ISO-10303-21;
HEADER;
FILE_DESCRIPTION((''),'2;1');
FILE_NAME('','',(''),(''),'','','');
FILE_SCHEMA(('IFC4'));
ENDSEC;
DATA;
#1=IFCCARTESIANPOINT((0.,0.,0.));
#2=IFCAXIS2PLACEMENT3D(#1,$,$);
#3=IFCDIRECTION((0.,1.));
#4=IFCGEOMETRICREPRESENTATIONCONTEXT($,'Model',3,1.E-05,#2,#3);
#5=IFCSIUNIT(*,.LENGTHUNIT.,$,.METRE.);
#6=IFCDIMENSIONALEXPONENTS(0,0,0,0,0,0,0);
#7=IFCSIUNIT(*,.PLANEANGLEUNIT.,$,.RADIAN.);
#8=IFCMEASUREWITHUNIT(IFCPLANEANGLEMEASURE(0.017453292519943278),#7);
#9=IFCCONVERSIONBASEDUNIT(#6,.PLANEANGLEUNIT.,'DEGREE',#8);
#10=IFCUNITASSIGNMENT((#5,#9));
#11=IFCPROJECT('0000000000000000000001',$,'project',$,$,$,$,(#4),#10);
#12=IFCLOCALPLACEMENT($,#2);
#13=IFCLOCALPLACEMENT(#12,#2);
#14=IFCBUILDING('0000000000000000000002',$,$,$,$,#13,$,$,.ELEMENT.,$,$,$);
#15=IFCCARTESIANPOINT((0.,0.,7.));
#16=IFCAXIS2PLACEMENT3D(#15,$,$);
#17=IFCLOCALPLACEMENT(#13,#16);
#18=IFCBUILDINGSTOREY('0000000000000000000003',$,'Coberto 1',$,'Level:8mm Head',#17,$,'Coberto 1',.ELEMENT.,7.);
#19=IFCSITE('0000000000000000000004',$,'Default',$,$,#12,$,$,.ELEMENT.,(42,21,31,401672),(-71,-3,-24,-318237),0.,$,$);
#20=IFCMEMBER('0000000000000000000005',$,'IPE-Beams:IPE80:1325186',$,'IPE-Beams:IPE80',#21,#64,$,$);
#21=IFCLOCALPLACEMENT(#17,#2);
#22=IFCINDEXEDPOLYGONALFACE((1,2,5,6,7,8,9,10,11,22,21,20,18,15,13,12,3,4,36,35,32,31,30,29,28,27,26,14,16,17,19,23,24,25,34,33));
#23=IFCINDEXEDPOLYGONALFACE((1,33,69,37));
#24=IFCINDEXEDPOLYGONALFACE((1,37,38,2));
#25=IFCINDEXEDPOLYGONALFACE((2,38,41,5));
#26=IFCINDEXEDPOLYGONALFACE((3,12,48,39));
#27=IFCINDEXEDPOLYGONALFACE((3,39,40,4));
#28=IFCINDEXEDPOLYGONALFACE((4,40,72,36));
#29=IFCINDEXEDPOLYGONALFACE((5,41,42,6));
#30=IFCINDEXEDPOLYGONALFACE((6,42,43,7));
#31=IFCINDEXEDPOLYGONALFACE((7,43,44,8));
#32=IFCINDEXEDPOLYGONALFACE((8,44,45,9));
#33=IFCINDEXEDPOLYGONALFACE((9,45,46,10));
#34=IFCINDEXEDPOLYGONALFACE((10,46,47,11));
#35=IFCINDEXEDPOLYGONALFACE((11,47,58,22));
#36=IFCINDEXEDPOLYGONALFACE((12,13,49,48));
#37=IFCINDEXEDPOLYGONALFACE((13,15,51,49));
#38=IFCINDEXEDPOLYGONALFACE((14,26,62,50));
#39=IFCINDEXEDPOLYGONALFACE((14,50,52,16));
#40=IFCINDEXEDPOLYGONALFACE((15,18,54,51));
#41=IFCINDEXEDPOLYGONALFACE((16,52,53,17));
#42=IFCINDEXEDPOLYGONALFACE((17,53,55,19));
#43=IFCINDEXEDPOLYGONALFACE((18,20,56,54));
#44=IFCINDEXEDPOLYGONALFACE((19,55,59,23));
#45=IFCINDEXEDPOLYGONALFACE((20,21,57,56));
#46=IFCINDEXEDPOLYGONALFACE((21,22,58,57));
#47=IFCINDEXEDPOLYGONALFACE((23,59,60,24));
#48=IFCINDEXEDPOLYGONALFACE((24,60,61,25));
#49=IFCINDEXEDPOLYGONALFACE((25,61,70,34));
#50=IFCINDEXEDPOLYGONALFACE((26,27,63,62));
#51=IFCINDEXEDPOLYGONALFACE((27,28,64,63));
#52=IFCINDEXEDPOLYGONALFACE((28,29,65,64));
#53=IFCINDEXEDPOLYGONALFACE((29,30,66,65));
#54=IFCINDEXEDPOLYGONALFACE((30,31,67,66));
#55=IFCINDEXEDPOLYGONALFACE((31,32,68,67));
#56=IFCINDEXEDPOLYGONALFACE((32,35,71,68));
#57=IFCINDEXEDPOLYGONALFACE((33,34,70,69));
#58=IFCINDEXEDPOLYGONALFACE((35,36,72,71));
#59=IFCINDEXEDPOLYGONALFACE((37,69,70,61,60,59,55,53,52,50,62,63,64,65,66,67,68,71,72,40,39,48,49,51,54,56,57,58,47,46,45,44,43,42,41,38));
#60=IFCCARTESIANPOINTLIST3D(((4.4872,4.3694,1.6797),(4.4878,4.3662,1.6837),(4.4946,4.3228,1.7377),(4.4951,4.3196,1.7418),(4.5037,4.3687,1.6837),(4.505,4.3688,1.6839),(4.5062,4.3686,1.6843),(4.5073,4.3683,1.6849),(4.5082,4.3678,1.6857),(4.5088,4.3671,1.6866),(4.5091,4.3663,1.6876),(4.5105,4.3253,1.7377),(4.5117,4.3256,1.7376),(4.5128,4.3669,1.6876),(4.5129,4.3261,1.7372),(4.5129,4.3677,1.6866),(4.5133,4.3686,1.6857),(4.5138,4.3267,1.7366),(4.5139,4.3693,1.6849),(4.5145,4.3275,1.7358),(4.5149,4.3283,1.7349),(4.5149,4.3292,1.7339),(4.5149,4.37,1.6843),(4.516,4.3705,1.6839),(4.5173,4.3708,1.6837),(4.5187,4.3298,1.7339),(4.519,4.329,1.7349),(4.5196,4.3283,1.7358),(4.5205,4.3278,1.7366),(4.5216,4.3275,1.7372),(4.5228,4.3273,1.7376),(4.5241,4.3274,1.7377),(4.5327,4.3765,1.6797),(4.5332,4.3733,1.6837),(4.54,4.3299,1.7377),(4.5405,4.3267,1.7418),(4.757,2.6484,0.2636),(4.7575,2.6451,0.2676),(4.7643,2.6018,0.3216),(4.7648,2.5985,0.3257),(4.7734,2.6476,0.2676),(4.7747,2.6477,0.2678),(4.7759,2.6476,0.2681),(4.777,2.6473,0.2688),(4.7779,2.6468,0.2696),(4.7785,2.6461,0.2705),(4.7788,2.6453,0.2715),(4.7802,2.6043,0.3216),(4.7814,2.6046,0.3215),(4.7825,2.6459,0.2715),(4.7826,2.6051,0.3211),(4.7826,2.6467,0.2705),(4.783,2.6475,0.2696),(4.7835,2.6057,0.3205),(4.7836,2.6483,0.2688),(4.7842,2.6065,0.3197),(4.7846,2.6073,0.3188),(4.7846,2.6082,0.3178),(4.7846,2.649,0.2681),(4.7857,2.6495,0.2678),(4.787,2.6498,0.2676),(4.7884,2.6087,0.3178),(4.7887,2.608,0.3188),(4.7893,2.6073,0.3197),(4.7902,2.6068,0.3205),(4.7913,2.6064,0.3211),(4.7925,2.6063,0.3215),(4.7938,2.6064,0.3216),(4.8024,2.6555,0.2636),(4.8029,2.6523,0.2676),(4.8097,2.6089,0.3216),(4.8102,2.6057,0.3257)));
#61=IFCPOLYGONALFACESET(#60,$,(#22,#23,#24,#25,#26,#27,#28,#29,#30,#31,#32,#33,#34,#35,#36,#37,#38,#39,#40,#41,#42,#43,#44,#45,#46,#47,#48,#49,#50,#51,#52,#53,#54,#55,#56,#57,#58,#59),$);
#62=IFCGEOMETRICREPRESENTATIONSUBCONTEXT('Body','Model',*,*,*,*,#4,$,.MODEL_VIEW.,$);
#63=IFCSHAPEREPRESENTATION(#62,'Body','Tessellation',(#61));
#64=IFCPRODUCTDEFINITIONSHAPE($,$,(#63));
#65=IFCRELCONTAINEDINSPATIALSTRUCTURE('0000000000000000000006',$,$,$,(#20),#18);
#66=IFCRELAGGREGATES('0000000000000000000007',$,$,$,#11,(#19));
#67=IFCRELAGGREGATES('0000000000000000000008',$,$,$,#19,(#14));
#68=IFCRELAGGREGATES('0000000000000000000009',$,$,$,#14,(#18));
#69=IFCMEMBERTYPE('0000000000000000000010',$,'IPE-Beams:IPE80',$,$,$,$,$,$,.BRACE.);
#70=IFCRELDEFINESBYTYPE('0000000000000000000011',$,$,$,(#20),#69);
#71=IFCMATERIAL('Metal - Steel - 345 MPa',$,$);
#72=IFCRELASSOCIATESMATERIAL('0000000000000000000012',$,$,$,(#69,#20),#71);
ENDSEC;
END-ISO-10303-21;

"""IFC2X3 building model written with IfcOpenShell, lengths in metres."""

from ifc_helpers import new_model, entity, si_unit, converted_unit, direction, frame, frame_2d, origin, place, context, subcontext, project, spatial, polyline, circle_curve, parameter, trimmed, segment, composite_curve, outline, extrude, source, transform, mapped, material, type_object, type_shapes, element, save


model = new_model("IFC2X3")

# Units and contexts
model_context = context("Model", 3, precision=1e-05, world=origin(), true_north=direction((0.0, 1.0)))
body_context = subcontext(model_context, "Body", "Model", "MODEL_VIEW")
ifc_project = project(units=[si_unit("LENGTHUNIT", "METRE"), converted_unit("PLANEANGLEUNIT", "DEGREE", entity("IfcPlaneAngleMeasure", 0.017453292519943278), si_unit("PLANEANGLEUNIT", "RADIAN"), dimensions=[0, 0, 0, 0, 0, 0, 0])], contexts=[model_context])

# Site, building, storey
site_placement = place(None, origin())
site = spatial("IfcSite", under=ifc_project, at=site_placement, Name="Default", CompositionType="ELEMENT", RefLatitude=(42, 21, 31, 401672), RefLongitude=(-71, -3, -24, -318237), RefElevation=0.0)
building_placement = place(site_placement, origin())
building = spatial("IfcBuilding", under=site, at=building_placement, CompositionType="ELEMENT")
storey_placement = place(building_placement, frame((0.0, 0.0, 7.0)))
storey = spatial("IfcBuildingStorey", under=building, at=storey_placement, Name="Coberto 1", ObjectType="Level:8mm Head", LongName="Coberto 1", CompositionType="ELEMENT", Elevation=7.0)

# Shared definitions
ifc_material_1 = material(Name="Metal - Steel - 345 MPa")

# Member
member_type_1 = type_object("IfcMemberType", Name="IPE-Beams:IPE80", PredefinedType="BRACE", material=ifc_material_1)
shared_shape_1 = source(origin(), body_context, "Body", "SweptSolid", [
    extrude(outline(composite_curve([segment(polyline([(-0.023, -0.0348), (-0.023, -0.04)]), True, "CONTINUOUS"), segment(polyline([(-0.023, -0.04), (0.023, -0.04)]), True, "CONTINUOUS"), segment(polyline([(0.023, -0.04), (0.023, -0.0348)]), True, "CONTINUOUS"), segment(polyline([(0.023, -0.0348), (0.0069, -0.0348)]), True, "CONTINUOUS"), segment(trimmed(circle_curve(frame_2d((0.0069, -0.0298), x_axis=(1.0, 0.0)), 0.005), [parameter(180.0)], [parameter(270.0)], True, "PARAMETER"), False, "CONTINUOUS"), segment(polyline([(0.0019, -0.0298), (0.0019, 0.0298)]), True, "CONTINUOUS"), segment(trimmed(circle_curve(frame_2d((0.0069, 0.0298), x_axis=(1.0, 0.0)), 0.005), [parameter(90.0)], [parameter(180.0)], True, "PARAMETER"), False, "CONTINUOUS"), segment(polyline([(0.0069, 0.0348), (0.023, 0.0348)]), True, "CONTINUOUS"), segment(polyline([(0.023, 0.0348), (0.023, 0.04)]), True, "CONTINUOUS"), segment(polyline([(0.023, 0.04), (-0.023, 0.04)]), True, "CONTINUOUS"), segment(polyline([(-0.023, 0.04), (-0.023, 0.0348)]), True, "CONTINUOUS"), segment(polyline([(-0.023, 0.0348), (-0.0069, 0.0348)]), True, "CONTINUOUS"), segment(trimmed(circle_curve(frame_2d((-0.0069, 0.0298), x_axis=(1.0, 0.0)), 0.005), [parameter(360.0)], [parameter(90.0)], True, "PARAMETER"), False, "CONTINUOUS"), segment(polyline([(-0.0019, 0.0298), (-0.0019, -0.0298)]), True, "CONTINUOUS"), segment(trimmed(circle_curve(frame_2d((-0.0069, -0.0298), x_axis=(1.0, 0.0)), 0.005), [parameter(270.0)], [parameter(0.0)], True, "PARAMETER"), False, "CONTINUOUS"), segment(polyline([(-0.0069, -0.0348), (-0.023, -0.0348)]), True, "CONTINUOUS")], self_intersect=False)), frame((-1.1005, 0.0, 0.0), z_axis=(-1.0, 0.0, 0.0), x_axis=(0.0, -1.0, 0.0)), (0.0, 0.0, -1.0), 2.245),
])
type_shapes(member_type_1, [shared_shape_1])
member_1_placement = place(storey_placement, frame((4.6461, 3.5044, 1.0166), z_axis=(0.097659, -0.62318, 0.775957), x_axis=(0.120135, -0.766601, -0.630786)))
element("IfcMember", 1, at=member_1_placement, inside=storey, type_object=member_type_1, material=ifc_material_1, Name="IPE-Beams:IPE80:1325186", ObjectType="IPE-Beams:IPE80", context=body_context, shape_type="MappedRepresentation", body=[
    mapped(shared_shape_1, transform((0.0, 0.0, 0.0), scale=1.0)),
])

save(model, "model.ifc")
